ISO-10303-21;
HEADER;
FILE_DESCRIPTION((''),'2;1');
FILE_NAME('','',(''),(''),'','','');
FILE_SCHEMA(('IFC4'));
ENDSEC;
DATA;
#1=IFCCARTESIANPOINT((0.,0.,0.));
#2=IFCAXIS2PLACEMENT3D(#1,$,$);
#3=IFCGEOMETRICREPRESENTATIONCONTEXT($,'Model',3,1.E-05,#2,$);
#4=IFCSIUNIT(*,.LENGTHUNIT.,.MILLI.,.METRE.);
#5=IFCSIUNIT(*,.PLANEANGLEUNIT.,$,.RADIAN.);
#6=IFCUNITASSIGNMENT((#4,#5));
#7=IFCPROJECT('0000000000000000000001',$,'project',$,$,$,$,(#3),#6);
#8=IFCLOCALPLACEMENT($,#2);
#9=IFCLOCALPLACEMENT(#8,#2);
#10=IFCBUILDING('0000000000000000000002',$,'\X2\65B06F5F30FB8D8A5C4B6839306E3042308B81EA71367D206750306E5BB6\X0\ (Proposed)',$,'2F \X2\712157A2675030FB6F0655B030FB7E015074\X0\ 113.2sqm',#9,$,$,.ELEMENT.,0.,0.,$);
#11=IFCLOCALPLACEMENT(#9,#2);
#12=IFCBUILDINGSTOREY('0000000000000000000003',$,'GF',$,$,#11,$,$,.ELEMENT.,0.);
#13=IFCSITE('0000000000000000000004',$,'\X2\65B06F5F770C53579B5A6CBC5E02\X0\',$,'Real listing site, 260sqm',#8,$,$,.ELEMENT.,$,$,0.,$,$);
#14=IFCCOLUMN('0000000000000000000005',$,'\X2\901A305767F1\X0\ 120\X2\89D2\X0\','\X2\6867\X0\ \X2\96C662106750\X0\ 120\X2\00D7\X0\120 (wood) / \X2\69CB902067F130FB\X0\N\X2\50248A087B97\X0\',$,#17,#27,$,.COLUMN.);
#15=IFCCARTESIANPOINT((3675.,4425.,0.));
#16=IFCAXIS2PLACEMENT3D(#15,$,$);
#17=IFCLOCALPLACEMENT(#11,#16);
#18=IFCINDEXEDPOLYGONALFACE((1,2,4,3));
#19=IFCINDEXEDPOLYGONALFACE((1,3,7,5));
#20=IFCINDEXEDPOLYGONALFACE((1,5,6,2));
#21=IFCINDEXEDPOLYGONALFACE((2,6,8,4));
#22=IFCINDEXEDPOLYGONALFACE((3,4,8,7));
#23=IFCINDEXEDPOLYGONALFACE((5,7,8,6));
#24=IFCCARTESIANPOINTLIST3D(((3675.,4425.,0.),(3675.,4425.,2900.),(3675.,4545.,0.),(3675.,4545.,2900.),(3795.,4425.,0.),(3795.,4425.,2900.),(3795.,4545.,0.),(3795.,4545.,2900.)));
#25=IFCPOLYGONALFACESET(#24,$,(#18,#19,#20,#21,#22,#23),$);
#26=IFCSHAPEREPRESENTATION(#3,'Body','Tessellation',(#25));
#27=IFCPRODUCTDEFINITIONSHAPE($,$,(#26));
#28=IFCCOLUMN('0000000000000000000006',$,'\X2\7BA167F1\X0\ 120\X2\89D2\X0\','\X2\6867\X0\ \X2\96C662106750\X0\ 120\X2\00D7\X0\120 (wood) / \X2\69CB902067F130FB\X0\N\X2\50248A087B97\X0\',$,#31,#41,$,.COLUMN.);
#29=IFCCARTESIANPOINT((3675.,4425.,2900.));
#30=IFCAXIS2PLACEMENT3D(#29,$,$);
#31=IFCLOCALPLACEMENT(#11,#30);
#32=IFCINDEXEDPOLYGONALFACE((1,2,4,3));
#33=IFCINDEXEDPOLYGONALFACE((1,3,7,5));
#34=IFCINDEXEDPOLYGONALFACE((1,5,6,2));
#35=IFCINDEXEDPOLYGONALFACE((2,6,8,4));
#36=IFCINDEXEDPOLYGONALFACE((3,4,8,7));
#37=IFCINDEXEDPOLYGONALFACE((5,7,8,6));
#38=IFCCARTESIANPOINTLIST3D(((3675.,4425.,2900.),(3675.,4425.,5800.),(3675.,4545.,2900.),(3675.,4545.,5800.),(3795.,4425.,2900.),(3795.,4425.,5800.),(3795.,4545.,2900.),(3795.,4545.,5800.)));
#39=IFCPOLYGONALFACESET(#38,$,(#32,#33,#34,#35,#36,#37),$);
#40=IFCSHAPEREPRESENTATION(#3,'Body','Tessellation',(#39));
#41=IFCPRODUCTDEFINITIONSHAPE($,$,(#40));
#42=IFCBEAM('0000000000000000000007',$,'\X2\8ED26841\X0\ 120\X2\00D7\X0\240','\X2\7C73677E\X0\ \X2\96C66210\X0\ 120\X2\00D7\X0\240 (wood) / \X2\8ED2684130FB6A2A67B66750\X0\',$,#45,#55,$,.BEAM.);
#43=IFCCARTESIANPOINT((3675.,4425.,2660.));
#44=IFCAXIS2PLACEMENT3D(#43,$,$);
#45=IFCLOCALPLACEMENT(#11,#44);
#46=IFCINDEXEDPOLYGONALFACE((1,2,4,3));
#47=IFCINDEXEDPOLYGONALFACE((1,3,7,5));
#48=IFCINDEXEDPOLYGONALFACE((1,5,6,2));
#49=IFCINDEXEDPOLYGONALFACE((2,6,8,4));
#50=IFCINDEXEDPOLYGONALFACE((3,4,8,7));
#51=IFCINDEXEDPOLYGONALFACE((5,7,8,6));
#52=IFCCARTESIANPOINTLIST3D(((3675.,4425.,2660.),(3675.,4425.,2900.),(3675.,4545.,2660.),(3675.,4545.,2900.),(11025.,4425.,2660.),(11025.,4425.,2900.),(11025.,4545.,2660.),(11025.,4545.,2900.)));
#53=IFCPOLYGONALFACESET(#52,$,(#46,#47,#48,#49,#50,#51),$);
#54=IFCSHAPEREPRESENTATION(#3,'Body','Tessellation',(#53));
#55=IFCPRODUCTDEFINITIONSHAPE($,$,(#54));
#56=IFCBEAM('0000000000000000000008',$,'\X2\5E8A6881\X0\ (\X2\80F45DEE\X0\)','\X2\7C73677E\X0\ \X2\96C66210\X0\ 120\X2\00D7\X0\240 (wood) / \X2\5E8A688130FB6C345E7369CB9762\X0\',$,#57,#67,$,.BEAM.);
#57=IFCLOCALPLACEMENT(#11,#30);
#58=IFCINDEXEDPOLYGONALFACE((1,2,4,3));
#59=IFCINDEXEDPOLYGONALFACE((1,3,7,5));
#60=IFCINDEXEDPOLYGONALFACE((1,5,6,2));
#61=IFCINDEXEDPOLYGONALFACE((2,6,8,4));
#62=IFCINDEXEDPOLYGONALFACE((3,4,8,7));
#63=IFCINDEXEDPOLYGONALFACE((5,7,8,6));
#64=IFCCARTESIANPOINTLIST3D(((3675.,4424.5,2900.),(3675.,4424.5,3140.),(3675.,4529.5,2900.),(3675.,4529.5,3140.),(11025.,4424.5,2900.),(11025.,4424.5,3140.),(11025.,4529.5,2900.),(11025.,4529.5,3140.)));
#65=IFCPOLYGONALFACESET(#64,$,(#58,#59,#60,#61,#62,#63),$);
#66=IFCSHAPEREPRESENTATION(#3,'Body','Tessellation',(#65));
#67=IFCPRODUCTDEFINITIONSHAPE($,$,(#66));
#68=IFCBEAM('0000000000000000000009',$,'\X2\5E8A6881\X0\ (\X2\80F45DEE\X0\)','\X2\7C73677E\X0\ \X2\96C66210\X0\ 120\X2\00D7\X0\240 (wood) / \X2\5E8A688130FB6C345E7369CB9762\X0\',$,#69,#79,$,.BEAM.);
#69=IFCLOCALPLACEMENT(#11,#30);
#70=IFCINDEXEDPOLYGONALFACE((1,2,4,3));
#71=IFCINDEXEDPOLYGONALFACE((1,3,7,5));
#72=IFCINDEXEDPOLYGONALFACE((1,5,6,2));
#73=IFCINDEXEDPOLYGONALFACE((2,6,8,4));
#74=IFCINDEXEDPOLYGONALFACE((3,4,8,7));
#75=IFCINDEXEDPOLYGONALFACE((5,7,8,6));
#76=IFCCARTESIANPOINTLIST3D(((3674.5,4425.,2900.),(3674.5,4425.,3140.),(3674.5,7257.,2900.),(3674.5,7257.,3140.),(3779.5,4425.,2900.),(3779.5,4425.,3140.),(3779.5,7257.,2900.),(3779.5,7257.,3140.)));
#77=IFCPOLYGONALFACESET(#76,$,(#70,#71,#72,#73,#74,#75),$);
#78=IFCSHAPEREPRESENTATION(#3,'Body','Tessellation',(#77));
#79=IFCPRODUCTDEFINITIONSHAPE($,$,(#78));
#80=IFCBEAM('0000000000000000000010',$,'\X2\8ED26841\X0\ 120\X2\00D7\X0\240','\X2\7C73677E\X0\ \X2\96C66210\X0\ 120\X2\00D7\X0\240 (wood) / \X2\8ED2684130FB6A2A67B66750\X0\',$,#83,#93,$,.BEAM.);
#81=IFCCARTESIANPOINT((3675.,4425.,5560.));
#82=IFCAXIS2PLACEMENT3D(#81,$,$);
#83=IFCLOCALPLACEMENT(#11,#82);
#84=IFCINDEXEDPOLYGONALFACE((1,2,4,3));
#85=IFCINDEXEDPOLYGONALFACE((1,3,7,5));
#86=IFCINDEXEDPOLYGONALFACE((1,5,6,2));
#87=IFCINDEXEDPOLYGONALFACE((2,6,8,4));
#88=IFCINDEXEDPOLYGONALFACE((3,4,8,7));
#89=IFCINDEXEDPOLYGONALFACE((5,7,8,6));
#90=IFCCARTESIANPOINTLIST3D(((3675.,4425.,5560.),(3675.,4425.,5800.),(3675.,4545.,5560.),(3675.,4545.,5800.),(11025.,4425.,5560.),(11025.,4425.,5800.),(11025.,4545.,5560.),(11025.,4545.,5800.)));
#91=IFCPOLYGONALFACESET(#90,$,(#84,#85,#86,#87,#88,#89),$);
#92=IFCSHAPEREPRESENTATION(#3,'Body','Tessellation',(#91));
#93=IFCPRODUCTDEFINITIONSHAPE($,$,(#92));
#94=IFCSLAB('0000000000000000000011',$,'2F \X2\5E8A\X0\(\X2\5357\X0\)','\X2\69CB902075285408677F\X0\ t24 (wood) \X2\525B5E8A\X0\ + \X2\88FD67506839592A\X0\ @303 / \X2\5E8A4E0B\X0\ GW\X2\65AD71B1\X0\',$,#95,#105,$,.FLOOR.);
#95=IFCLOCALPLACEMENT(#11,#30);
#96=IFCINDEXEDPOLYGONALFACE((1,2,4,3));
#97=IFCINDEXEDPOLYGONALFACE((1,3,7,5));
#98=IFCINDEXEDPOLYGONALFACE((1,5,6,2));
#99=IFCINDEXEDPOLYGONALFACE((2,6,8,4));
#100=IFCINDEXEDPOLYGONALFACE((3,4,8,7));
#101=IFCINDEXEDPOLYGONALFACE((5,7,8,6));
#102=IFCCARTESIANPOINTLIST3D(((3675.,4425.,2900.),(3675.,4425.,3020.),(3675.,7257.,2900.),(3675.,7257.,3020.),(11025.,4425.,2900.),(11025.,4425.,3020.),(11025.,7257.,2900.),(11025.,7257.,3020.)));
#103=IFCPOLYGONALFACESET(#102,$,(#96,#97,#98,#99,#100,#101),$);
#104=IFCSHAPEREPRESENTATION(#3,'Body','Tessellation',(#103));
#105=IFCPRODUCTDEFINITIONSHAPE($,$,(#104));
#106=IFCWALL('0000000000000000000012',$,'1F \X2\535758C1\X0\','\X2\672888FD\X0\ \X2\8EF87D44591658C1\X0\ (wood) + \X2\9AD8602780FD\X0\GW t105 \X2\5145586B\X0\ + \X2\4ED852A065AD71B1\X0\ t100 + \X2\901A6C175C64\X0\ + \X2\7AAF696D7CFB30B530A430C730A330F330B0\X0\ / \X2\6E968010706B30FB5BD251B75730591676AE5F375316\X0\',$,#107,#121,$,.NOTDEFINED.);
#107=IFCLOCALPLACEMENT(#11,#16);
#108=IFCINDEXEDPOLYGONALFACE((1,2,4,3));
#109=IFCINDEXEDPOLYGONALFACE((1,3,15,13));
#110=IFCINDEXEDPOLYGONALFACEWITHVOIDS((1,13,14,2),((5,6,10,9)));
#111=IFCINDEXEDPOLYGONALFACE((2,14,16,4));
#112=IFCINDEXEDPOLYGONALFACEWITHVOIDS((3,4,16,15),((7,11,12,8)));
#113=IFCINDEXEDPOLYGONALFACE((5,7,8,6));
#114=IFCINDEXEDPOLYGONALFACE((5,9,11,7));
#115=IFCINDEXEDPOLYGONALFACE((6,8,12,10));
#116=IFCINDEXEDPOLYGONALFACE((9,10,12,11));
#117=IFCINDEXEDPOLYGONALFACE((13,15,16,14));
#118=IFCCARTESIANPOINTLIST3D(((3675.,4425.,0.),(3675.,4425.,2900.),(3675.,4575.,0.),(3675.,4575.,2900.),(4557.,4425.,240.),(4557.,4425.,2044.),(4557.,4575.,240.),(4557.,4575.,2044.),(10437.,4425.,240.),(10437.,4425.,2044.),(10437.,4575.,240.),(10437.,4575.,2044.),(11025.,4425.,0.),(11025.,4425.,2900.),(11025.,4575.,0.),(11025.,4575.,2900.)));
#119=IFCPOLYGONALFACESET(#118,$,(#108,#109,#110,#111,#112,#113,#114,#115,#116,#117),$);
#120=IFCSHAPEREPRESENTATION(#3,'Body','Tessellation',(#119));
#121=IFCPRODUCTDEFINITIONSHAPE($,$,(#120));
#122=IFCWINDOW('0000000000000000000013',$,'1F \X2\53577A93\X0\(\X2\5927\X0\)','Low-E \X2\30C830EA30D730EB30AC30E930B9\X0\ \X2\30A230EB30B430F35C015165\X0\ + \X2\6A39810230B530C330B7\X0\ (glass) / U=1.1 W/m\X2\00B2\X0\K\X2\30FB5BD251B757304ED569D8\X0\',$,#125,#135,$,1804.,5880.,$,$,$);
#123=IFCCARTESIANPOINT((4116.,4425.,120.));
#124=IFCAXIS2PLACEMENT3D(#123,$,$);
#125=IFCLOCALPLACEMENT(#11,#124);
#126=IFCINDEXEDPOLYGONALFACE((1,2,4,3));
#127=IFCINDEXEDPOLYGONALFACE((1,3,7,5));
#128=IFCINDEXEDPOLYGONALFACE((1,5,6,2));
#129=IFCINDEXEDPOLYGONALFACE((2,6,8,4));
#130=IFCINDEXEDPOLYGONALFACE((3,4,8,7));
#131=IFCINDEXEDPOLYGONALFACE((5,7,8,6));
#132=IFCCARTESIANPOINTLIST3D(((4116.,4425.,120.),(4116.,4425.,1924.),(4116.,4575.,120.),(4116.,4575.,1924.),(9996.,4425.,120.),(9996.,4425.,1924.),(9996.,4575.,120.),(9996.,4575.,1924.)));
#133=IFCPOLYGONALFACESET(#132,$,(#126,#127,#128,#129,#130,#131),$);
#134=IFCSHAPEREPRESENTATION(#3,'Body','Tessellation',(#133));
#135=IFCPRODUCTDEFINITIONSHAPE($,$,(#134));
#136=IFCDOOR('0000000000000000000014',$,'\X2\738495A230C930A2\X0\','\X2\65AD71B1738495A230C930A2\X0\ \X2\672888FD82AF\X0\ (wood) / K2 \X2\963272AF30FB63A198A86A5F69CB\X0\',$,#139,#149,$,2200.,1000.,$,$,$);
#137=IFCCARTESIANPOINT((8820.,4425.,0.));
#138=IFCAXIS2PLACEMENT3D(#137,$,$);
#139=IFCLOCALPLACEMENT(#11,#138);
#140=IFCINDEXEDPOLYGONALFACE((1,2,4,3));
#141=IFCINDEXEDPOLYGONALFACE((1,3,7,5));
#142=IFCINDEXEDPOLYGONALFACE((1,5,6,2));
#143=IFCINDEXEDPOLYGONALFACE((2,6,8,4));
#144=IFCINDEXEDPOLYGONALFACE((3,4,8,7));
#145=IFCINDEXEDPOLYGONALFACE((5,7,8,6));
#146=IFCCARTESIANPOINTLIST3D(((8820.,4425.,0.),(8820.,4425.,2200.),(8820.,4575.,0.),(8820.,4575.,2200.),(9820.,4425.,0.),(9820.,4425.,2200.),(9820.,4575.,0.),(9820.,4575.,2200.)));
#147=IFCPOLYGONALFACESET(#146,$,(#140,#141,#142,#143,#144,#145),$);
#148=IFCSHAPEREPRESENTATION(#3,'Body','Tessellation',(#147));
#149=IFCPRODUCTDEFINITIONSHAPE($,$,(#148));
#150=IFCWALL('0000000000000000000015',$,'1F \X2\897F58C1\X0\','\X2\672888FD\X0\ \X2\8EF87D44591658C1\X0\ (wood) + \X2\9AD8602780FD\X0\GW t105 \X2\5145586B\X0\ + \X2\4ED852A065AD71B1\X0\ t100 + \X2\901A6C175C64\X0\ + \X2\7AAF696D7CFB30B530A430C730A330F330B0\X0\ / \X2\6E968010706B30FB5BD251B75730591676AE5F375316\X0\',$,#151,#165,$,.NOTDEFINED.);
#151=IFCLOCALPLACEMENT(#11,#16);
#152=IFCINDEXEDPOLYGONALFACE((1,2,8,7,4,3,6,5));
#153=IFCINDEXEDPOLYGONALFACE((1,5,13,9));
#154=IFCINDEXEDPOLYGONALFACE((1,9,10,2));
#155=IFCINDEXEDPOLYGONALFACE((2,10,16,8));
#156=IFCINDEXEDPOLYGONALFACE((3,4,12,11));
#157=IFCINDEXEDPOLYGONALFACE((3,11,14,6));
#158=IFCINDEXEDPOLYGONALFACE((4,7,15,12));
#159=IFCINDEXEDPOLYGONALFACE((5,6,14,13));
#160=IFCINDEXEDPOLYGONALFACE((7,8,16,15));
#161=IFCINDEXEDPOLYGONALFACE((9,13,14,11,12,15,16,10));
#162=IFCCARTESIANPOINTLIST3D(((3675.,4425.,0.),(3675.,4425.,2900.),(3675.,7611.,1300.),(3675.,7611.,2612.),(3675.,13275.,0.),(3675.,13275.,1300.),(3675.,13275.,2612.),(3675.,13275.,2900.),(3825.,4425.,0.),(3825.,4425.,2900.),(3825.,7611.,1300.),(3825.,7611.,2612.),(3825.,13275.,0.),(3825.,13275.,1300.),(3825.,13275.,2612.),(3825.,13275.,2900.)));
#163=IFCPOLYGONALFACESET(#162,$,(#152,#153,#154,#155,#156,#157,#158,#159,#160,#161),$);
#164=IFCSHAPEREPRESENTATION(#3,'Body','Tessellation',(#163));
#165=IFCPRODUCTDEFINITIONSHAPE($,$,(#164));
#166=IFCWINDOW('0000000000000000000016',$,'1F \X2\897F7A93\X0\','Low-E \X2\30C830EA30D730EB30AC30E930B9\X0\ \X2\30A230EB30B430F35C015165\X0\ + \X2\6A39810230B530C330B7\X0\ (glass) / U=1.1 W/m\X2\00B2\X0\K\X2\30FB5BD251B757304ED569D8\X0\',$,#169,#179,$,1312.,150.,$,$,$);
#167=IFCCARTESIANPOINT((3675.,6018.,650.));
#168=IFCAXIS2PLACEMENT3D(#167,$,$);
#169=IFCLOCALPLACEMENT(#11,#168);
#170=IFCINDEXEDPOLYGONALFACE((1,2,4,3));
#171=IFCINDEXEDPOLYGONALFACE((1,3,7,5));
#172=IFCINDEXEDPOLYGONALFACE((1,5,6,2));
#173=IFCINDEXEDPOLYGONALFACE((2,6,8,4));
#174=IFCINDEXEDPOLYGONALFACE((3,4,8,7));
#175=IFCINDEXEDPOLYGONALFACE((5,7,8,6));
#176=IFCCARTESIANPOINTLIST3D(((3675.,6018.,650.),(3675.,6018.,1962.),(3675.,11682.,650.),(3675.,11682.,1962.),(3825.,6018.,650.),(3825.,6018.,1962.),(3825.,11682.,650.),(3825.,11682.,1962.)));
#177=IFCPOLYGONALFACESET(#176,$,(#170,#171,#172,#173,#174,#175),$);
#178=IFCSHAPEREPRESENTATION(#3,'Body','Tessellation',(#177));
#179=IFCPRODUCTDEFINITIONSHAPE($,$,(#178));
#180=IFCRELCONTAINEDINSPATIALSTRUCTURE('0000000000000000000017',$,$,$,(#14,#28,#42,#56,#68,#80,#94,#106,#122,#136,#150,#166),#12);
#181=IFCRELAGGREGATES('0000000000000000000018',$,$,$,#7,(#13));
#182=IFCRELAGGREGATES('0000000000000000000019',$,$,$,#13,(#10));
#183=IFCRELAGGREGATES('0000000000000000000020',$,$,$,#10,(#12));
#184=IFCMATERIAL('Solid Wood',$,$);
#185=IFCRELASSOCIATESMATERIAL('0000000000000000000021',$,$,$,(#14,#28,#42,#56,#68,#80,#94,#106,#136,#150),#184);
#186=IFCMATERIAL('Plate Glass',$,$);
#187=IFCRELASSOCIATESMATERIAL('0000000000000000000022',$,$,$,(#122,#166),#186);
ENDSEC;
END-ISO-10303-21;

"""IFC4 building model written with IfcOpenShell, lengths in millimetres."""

from ifc_helpers import new_model, si_unit, frame, frame_2d, origin, place, context, project, spatial, rectangle, extrude, material, element, fill, save


model = new_model("IFC4")

# Units and contexts
model_context = context("Model", 3, precision=1e-05, world=origin())
ifc_project = project(units=[si_unit("LENGTHUNIT", "METRE", prefix="MILLI"), si_unit("PLANEANGLEUNIT", "RADIAN")], contexts=[model_context])

# Site, building, storey
site_placement = place(None, origin())
site = spatial("IfcSite", under=ifc_project, at=site_placement, Name="新潟県南魚沼市", ObjectType="Real listing site, 260sqm", CompositionType="ELEMENT", RefElevation=0.0)
building_placement = place(site_placement, origin())
building = spatial("IfcBuilding", under=site, at=building_placement, Name="新潟・越屋根のある自然素材の家 (Proposed)", ObjectType="2F 無垢材・漆喰・縁側 113.2sqm", CompositionType="ELEMENT", ElevationOfRefHeight=0.0, ElevationOfTerrain=0.0)
storey_placement = place(building_placement, origin())
storey = spatial("IfcBuildingStorey", under=building, at=storey_placement, Name="GF", CompositionType="ELEMENT", Elevation=0.0)

# Columns
ifc_material_1 = material(Name="Solid Wood")
column_1_placement = place(storey_placement, frame((3675.0, 4425.0, 0.0)))
element("IfcColumn", 1, at=column_1_placement, inside=storey, material=ifc_material_1, Name="通し柱 120角", Description="桧 集成材 120×120 (wood) / 構造柱・N値計算", PredefinedType="COLUMN", context=model_context, shape_type="SweptSolid", body=[
    extrude(rectangle(XDim=120.0, YDim=120.0, at=frame_2d((60.0, 60.0))), frame((3675.0, 4425.0, 0.0)), (0.0, 0.0, 1.0), 2900.0),
])
column_2_placement = place(storey_placement, frame((3675.0, 4425.0, 2900.0)))
element("IfcColumn", 2, at=column_2_placement, inside=storey, material=ifc_material_1, Name="管柱 120角", Description="桧 集成材 120×120 (wood) / 構造柱・N値計算", PredefinedType="COLUMN", context=model_context, shape_type="SweptSolid", body=[
    extrude(rectangle(XDim=120.0, YDim=120.0, at=frame_2d((60.0, 60.0))), frame((3675.0, 4425.0, 2900.0)), (0.0, 0.0, 1.0), 2900.0),
])

# Beams
beam_1_placement = place(storey_placement, frame((3675.0, 4425.0, 2660.0)))
element("IfcBeam", 3, at=beam_1_placement, inside=storey, material=ifc_material_1, Name="軒桁 120×240", Description="米松 集成 120×240 (wood) / 軒桁・横架材", PredefinedType="BEAM", context=model_context, shape_type="SweptSolid", body=[
    extrude(rectangle(XDim=7350.0, YDim=120.0, at=frame_2d((3675.0, 60.0))), frame((3675.0, 4425.0, 2660.0)), (0.0, 0.0, 1.0), 240.0),
])
beam_2_placement = place(storey_placement, frame((3675.0, 4425.0, 2900.0)))
element("IfcBeam", 4, at=beam_2_placement, inside=storey, material=ifc_material_1, Name="床梁 (胴差)", Description="米松 集成 120×240 (wood) / 床梁・水平構面", PredefinedType="BEAM", context=model_context, shape_type="SweptSolid", body=[
    extrude(rectangle(XDim=7350.0, YDim=105.0, at=frame_2d((3675.0, 52.0))), frame((3675.0, 4425.0, 2900.0)), (0.0, 0.0, 1.0), 240.0),
])
beam_3_placement = place(storey_placement, frame((3675.0, 4425.0, 2900.0)))
element("IfcBeam", 5, at=beam_3_placement, inside=storey, material=ifc_material_1, Name="床梁 (胴差)", Description="米松 集成 120×240 (wood) / 床梁・水平構面", PredefinedType="BEAM", context=model_context, shape_type="SweptSolid", body=[
    extrude(rectangle(XDim=105.0, YDim=2832.0, at=frame_2d((52.0, 1416.0))), frame((3675.0, 4425.0, 2900.0)), (0.0, 0.0, 1.0), 240.0),
])
beam_4_placement = place(storey_placement, frame((3675.0, 4425.0, 5560.0)))
element("IfcBeam", 6, at=beam_4_placement, inside=storey, material=ifc_material_1, Name="軒桁 120×240", Description="米松 集成 120×240 (wood) / 軒桁・横架材", PredefinedType="BEAM", context=model_context, shape_type="SweptSolid", body=[
    extrude(rectangle(XDim=7350.0, YDim=120.0, at=frame_2d((3675.0, 60.0))), frame((3675.0, 4425.0, 5560.0)), (0.0, 0.0, 1.0), 240.0),
])

# Slab
slab_1_placement = place(storey_placement, frame((3675.0, 4425.0, 2900.0)))
element("IfcSlab", 7, at=slab_1_placement, inside=storey, material=ifc_material_1, Name="2F 床(南)", Description="構造用合板 t24 (wood) 剛床 + 製材根太 @303 / 床下 GW断熱", PredefinedType="FLOOR", context=model_context, shape_type="SweptSolid", body=[
    extrude(rectangle(XDim=7350.0, YDim=2832.0, at=frame_2d((3675.0, 1416.0))), frame((3675.0, 4425.0, 2900.0)), (0.0, 0.0, 1.0), 120.0),
])

# Wall, openings, window, door
wall_1_placement = place(storey_placement, frame((3675.0, 4425.0, 0.0)))
wall_1 = element("IfcWall", 8, at=wall_1_placement, inside=storey, material=ifc_material_1, Name="1F 南壁", Description="木製 軸組外壁 (wood) + 高性能GW t105 充填 + 付加断熱 t100 + 通気層 + 窯業系サイディング / 準耐火・寒冷地外皮強化", PredefinedType="NOTDEFINED", context=model_context, shape_type="SweptSolid", body=[
    extrude(rectangle(XDim=7350.0, YDim=150.0, at=frame_2d((3675.0, 75.0))), frame((3675.0, 4425.0, 0.0)), (0.0, 0.0, 1.0), 2900.0),
])
opening_1_placement = place(storey_placement, frame((4116.0, 4425.0, 120.0)))
opening_1 = element("IfcOpeningElement", 9, at=opening_1_placement, cuts=wall_1, PredefinedType="NOTDEFINED", context=model_context, shape_type="SweptSolid", body=[
    extrude(rectangle(XDim=5880.0, YDim=150.0, at=frame_2d((2940.0, 75.0))), frame((4116.0, 4425.0, 120.0)), (0.0, 0.0, 1.0), 1804.0),
])
opening_2_placement = place(storey_placement, frame((8820.0, 4425.0, 0.0)))
opening_2 = element("IfcOpeningElement", 10, at=opening_2_placement, cuts=wall_1, PredefinedType="NOTDEFINED", context=model_context, shape_type="SweptSolid", body=[
    extrude(rectangle(XDim=1000.0, YDim=150.0, at=frame_2d((500.0, 75.0))), frame((8820.0, 4425.0, 0.0)), (0.0, 0.0, 1.0), 2200.0),
])
ifc_material_2 = material(Name="Plate Glass")
window_1_placement = place(storey_placement, frame((4116.0, 4425.0, 120.0)))
window_1 = element("IfcWindow", 11, at=window_1_placement, inside=storey, material=ifc_material_2, Name="1F 南窓(大)", Description="Low-E トリプルガラス アルゴン封入 + 樹脂サッシ (glass) / U=1.1 W/m²K・寒冷地仕様", OverallHeight=1804.0, OverallWidth=5880.0, context=model_context, shape_type="SweptSolid", body=[
    extrude(rectangle(XDim=5880.0, YDim=150.0, at=frame_2d((2940.0, 75.0))), frame((4116.0, 4425.0, 120.0)), (0.0, 0.0, 1.0), 1804.0),
])
fill(opening_1, window_1)
door_placement = place(storey_placement, frame((8820.0, 4425.0, 0.0)))
door = element("IfcDoor", 12, at=door_placement, inside=storey, material=ifc_material_1, Name="玄関ドア", Description="断熱玄関ドア 木製芯 (wood) / K2 防犯・採風機構", OverallHeight=2200.0, OverallWidth=1000.0, context=model_context, shape_type="SweptSolid", body=[
    extrude(rectangle(XDim=1000.0, YDim=150.0, at=frame_2d((500.0, 75.0))), frame((8820.0, 4425.0, 0.0)), (0.0, 0.0, 1.0), 2200.0),
])
fill(opening_2, door)

# Wall, opening, window
wall_2_placement = place(storey_placement, frame((3675.0, 4425.0, 0.0)))
wall_2 = element("IfcWall", 13, at=wall_2_placement, inside=storey, material=ifc_material_1, Name="1F 西壁", Description="木製 軸組外壁 (wood) + 高性能GW t105 充填 + 付加断熱 t100 + 通気層 + 窯業系サイディング / 準耐火・寒冷地外皮強化", PredefinedType="NOTDEFINED", context=model_context, shape_type="SweptSolid", body=[
    extrude(rectangle(XDim=150.0, YDim=8850.0, at=frame_2d((75.0, 4425.0))), frame((3675.0, 4425.0, 0.0)), (0.0, 0.0, 1.0), 2900.0),
])
opening_3_placement = place(storey_placement, frame((3675.0, 6018.0, 650.0)))
opening_3 = element("IfcOpeningElement", 14, at=opening_3_placement, cuts=wall_2, PredefinedType="NOTDEFINED", context=model_context, shape_type="SweptSolid", body=[
    extrude(rectangle(XDim=150.0, YDim=5664.0, at=frame_2d((75.0, 2832.0))), frame((3675.0, 6018.0, 650.0)), (0.0, 0.0, 1.0), 1312.0),
])
window_2_placement = place(storey_placement, frame((3675.0, 6018.0, 650.0)))
window_2 = element("IfcWindow", 15, at=window_2_placement, inside=storey, material=ifc_material_2, Name="1F 西窓", Description="Low-E トリプルガラス アルゴン封入 + 樹脂サッシ (glass) / U=1.1 W/m²K・寒冷地仕様", OverallHeight=1312.0, OverallWidth=150.0, context=model_context, shape_type="SweptSolid", body=[
    extrude(rectangle(XDim=150.0, YDim=5664.0, at=frame_2d((75.0, 2832.0))), frame((3675.0, 6018.0, 650.0)), (0.0, 0.0, 1.0), 1312.0),
])
fill(opening_3, window_2)

save(model, "model.ifc")
